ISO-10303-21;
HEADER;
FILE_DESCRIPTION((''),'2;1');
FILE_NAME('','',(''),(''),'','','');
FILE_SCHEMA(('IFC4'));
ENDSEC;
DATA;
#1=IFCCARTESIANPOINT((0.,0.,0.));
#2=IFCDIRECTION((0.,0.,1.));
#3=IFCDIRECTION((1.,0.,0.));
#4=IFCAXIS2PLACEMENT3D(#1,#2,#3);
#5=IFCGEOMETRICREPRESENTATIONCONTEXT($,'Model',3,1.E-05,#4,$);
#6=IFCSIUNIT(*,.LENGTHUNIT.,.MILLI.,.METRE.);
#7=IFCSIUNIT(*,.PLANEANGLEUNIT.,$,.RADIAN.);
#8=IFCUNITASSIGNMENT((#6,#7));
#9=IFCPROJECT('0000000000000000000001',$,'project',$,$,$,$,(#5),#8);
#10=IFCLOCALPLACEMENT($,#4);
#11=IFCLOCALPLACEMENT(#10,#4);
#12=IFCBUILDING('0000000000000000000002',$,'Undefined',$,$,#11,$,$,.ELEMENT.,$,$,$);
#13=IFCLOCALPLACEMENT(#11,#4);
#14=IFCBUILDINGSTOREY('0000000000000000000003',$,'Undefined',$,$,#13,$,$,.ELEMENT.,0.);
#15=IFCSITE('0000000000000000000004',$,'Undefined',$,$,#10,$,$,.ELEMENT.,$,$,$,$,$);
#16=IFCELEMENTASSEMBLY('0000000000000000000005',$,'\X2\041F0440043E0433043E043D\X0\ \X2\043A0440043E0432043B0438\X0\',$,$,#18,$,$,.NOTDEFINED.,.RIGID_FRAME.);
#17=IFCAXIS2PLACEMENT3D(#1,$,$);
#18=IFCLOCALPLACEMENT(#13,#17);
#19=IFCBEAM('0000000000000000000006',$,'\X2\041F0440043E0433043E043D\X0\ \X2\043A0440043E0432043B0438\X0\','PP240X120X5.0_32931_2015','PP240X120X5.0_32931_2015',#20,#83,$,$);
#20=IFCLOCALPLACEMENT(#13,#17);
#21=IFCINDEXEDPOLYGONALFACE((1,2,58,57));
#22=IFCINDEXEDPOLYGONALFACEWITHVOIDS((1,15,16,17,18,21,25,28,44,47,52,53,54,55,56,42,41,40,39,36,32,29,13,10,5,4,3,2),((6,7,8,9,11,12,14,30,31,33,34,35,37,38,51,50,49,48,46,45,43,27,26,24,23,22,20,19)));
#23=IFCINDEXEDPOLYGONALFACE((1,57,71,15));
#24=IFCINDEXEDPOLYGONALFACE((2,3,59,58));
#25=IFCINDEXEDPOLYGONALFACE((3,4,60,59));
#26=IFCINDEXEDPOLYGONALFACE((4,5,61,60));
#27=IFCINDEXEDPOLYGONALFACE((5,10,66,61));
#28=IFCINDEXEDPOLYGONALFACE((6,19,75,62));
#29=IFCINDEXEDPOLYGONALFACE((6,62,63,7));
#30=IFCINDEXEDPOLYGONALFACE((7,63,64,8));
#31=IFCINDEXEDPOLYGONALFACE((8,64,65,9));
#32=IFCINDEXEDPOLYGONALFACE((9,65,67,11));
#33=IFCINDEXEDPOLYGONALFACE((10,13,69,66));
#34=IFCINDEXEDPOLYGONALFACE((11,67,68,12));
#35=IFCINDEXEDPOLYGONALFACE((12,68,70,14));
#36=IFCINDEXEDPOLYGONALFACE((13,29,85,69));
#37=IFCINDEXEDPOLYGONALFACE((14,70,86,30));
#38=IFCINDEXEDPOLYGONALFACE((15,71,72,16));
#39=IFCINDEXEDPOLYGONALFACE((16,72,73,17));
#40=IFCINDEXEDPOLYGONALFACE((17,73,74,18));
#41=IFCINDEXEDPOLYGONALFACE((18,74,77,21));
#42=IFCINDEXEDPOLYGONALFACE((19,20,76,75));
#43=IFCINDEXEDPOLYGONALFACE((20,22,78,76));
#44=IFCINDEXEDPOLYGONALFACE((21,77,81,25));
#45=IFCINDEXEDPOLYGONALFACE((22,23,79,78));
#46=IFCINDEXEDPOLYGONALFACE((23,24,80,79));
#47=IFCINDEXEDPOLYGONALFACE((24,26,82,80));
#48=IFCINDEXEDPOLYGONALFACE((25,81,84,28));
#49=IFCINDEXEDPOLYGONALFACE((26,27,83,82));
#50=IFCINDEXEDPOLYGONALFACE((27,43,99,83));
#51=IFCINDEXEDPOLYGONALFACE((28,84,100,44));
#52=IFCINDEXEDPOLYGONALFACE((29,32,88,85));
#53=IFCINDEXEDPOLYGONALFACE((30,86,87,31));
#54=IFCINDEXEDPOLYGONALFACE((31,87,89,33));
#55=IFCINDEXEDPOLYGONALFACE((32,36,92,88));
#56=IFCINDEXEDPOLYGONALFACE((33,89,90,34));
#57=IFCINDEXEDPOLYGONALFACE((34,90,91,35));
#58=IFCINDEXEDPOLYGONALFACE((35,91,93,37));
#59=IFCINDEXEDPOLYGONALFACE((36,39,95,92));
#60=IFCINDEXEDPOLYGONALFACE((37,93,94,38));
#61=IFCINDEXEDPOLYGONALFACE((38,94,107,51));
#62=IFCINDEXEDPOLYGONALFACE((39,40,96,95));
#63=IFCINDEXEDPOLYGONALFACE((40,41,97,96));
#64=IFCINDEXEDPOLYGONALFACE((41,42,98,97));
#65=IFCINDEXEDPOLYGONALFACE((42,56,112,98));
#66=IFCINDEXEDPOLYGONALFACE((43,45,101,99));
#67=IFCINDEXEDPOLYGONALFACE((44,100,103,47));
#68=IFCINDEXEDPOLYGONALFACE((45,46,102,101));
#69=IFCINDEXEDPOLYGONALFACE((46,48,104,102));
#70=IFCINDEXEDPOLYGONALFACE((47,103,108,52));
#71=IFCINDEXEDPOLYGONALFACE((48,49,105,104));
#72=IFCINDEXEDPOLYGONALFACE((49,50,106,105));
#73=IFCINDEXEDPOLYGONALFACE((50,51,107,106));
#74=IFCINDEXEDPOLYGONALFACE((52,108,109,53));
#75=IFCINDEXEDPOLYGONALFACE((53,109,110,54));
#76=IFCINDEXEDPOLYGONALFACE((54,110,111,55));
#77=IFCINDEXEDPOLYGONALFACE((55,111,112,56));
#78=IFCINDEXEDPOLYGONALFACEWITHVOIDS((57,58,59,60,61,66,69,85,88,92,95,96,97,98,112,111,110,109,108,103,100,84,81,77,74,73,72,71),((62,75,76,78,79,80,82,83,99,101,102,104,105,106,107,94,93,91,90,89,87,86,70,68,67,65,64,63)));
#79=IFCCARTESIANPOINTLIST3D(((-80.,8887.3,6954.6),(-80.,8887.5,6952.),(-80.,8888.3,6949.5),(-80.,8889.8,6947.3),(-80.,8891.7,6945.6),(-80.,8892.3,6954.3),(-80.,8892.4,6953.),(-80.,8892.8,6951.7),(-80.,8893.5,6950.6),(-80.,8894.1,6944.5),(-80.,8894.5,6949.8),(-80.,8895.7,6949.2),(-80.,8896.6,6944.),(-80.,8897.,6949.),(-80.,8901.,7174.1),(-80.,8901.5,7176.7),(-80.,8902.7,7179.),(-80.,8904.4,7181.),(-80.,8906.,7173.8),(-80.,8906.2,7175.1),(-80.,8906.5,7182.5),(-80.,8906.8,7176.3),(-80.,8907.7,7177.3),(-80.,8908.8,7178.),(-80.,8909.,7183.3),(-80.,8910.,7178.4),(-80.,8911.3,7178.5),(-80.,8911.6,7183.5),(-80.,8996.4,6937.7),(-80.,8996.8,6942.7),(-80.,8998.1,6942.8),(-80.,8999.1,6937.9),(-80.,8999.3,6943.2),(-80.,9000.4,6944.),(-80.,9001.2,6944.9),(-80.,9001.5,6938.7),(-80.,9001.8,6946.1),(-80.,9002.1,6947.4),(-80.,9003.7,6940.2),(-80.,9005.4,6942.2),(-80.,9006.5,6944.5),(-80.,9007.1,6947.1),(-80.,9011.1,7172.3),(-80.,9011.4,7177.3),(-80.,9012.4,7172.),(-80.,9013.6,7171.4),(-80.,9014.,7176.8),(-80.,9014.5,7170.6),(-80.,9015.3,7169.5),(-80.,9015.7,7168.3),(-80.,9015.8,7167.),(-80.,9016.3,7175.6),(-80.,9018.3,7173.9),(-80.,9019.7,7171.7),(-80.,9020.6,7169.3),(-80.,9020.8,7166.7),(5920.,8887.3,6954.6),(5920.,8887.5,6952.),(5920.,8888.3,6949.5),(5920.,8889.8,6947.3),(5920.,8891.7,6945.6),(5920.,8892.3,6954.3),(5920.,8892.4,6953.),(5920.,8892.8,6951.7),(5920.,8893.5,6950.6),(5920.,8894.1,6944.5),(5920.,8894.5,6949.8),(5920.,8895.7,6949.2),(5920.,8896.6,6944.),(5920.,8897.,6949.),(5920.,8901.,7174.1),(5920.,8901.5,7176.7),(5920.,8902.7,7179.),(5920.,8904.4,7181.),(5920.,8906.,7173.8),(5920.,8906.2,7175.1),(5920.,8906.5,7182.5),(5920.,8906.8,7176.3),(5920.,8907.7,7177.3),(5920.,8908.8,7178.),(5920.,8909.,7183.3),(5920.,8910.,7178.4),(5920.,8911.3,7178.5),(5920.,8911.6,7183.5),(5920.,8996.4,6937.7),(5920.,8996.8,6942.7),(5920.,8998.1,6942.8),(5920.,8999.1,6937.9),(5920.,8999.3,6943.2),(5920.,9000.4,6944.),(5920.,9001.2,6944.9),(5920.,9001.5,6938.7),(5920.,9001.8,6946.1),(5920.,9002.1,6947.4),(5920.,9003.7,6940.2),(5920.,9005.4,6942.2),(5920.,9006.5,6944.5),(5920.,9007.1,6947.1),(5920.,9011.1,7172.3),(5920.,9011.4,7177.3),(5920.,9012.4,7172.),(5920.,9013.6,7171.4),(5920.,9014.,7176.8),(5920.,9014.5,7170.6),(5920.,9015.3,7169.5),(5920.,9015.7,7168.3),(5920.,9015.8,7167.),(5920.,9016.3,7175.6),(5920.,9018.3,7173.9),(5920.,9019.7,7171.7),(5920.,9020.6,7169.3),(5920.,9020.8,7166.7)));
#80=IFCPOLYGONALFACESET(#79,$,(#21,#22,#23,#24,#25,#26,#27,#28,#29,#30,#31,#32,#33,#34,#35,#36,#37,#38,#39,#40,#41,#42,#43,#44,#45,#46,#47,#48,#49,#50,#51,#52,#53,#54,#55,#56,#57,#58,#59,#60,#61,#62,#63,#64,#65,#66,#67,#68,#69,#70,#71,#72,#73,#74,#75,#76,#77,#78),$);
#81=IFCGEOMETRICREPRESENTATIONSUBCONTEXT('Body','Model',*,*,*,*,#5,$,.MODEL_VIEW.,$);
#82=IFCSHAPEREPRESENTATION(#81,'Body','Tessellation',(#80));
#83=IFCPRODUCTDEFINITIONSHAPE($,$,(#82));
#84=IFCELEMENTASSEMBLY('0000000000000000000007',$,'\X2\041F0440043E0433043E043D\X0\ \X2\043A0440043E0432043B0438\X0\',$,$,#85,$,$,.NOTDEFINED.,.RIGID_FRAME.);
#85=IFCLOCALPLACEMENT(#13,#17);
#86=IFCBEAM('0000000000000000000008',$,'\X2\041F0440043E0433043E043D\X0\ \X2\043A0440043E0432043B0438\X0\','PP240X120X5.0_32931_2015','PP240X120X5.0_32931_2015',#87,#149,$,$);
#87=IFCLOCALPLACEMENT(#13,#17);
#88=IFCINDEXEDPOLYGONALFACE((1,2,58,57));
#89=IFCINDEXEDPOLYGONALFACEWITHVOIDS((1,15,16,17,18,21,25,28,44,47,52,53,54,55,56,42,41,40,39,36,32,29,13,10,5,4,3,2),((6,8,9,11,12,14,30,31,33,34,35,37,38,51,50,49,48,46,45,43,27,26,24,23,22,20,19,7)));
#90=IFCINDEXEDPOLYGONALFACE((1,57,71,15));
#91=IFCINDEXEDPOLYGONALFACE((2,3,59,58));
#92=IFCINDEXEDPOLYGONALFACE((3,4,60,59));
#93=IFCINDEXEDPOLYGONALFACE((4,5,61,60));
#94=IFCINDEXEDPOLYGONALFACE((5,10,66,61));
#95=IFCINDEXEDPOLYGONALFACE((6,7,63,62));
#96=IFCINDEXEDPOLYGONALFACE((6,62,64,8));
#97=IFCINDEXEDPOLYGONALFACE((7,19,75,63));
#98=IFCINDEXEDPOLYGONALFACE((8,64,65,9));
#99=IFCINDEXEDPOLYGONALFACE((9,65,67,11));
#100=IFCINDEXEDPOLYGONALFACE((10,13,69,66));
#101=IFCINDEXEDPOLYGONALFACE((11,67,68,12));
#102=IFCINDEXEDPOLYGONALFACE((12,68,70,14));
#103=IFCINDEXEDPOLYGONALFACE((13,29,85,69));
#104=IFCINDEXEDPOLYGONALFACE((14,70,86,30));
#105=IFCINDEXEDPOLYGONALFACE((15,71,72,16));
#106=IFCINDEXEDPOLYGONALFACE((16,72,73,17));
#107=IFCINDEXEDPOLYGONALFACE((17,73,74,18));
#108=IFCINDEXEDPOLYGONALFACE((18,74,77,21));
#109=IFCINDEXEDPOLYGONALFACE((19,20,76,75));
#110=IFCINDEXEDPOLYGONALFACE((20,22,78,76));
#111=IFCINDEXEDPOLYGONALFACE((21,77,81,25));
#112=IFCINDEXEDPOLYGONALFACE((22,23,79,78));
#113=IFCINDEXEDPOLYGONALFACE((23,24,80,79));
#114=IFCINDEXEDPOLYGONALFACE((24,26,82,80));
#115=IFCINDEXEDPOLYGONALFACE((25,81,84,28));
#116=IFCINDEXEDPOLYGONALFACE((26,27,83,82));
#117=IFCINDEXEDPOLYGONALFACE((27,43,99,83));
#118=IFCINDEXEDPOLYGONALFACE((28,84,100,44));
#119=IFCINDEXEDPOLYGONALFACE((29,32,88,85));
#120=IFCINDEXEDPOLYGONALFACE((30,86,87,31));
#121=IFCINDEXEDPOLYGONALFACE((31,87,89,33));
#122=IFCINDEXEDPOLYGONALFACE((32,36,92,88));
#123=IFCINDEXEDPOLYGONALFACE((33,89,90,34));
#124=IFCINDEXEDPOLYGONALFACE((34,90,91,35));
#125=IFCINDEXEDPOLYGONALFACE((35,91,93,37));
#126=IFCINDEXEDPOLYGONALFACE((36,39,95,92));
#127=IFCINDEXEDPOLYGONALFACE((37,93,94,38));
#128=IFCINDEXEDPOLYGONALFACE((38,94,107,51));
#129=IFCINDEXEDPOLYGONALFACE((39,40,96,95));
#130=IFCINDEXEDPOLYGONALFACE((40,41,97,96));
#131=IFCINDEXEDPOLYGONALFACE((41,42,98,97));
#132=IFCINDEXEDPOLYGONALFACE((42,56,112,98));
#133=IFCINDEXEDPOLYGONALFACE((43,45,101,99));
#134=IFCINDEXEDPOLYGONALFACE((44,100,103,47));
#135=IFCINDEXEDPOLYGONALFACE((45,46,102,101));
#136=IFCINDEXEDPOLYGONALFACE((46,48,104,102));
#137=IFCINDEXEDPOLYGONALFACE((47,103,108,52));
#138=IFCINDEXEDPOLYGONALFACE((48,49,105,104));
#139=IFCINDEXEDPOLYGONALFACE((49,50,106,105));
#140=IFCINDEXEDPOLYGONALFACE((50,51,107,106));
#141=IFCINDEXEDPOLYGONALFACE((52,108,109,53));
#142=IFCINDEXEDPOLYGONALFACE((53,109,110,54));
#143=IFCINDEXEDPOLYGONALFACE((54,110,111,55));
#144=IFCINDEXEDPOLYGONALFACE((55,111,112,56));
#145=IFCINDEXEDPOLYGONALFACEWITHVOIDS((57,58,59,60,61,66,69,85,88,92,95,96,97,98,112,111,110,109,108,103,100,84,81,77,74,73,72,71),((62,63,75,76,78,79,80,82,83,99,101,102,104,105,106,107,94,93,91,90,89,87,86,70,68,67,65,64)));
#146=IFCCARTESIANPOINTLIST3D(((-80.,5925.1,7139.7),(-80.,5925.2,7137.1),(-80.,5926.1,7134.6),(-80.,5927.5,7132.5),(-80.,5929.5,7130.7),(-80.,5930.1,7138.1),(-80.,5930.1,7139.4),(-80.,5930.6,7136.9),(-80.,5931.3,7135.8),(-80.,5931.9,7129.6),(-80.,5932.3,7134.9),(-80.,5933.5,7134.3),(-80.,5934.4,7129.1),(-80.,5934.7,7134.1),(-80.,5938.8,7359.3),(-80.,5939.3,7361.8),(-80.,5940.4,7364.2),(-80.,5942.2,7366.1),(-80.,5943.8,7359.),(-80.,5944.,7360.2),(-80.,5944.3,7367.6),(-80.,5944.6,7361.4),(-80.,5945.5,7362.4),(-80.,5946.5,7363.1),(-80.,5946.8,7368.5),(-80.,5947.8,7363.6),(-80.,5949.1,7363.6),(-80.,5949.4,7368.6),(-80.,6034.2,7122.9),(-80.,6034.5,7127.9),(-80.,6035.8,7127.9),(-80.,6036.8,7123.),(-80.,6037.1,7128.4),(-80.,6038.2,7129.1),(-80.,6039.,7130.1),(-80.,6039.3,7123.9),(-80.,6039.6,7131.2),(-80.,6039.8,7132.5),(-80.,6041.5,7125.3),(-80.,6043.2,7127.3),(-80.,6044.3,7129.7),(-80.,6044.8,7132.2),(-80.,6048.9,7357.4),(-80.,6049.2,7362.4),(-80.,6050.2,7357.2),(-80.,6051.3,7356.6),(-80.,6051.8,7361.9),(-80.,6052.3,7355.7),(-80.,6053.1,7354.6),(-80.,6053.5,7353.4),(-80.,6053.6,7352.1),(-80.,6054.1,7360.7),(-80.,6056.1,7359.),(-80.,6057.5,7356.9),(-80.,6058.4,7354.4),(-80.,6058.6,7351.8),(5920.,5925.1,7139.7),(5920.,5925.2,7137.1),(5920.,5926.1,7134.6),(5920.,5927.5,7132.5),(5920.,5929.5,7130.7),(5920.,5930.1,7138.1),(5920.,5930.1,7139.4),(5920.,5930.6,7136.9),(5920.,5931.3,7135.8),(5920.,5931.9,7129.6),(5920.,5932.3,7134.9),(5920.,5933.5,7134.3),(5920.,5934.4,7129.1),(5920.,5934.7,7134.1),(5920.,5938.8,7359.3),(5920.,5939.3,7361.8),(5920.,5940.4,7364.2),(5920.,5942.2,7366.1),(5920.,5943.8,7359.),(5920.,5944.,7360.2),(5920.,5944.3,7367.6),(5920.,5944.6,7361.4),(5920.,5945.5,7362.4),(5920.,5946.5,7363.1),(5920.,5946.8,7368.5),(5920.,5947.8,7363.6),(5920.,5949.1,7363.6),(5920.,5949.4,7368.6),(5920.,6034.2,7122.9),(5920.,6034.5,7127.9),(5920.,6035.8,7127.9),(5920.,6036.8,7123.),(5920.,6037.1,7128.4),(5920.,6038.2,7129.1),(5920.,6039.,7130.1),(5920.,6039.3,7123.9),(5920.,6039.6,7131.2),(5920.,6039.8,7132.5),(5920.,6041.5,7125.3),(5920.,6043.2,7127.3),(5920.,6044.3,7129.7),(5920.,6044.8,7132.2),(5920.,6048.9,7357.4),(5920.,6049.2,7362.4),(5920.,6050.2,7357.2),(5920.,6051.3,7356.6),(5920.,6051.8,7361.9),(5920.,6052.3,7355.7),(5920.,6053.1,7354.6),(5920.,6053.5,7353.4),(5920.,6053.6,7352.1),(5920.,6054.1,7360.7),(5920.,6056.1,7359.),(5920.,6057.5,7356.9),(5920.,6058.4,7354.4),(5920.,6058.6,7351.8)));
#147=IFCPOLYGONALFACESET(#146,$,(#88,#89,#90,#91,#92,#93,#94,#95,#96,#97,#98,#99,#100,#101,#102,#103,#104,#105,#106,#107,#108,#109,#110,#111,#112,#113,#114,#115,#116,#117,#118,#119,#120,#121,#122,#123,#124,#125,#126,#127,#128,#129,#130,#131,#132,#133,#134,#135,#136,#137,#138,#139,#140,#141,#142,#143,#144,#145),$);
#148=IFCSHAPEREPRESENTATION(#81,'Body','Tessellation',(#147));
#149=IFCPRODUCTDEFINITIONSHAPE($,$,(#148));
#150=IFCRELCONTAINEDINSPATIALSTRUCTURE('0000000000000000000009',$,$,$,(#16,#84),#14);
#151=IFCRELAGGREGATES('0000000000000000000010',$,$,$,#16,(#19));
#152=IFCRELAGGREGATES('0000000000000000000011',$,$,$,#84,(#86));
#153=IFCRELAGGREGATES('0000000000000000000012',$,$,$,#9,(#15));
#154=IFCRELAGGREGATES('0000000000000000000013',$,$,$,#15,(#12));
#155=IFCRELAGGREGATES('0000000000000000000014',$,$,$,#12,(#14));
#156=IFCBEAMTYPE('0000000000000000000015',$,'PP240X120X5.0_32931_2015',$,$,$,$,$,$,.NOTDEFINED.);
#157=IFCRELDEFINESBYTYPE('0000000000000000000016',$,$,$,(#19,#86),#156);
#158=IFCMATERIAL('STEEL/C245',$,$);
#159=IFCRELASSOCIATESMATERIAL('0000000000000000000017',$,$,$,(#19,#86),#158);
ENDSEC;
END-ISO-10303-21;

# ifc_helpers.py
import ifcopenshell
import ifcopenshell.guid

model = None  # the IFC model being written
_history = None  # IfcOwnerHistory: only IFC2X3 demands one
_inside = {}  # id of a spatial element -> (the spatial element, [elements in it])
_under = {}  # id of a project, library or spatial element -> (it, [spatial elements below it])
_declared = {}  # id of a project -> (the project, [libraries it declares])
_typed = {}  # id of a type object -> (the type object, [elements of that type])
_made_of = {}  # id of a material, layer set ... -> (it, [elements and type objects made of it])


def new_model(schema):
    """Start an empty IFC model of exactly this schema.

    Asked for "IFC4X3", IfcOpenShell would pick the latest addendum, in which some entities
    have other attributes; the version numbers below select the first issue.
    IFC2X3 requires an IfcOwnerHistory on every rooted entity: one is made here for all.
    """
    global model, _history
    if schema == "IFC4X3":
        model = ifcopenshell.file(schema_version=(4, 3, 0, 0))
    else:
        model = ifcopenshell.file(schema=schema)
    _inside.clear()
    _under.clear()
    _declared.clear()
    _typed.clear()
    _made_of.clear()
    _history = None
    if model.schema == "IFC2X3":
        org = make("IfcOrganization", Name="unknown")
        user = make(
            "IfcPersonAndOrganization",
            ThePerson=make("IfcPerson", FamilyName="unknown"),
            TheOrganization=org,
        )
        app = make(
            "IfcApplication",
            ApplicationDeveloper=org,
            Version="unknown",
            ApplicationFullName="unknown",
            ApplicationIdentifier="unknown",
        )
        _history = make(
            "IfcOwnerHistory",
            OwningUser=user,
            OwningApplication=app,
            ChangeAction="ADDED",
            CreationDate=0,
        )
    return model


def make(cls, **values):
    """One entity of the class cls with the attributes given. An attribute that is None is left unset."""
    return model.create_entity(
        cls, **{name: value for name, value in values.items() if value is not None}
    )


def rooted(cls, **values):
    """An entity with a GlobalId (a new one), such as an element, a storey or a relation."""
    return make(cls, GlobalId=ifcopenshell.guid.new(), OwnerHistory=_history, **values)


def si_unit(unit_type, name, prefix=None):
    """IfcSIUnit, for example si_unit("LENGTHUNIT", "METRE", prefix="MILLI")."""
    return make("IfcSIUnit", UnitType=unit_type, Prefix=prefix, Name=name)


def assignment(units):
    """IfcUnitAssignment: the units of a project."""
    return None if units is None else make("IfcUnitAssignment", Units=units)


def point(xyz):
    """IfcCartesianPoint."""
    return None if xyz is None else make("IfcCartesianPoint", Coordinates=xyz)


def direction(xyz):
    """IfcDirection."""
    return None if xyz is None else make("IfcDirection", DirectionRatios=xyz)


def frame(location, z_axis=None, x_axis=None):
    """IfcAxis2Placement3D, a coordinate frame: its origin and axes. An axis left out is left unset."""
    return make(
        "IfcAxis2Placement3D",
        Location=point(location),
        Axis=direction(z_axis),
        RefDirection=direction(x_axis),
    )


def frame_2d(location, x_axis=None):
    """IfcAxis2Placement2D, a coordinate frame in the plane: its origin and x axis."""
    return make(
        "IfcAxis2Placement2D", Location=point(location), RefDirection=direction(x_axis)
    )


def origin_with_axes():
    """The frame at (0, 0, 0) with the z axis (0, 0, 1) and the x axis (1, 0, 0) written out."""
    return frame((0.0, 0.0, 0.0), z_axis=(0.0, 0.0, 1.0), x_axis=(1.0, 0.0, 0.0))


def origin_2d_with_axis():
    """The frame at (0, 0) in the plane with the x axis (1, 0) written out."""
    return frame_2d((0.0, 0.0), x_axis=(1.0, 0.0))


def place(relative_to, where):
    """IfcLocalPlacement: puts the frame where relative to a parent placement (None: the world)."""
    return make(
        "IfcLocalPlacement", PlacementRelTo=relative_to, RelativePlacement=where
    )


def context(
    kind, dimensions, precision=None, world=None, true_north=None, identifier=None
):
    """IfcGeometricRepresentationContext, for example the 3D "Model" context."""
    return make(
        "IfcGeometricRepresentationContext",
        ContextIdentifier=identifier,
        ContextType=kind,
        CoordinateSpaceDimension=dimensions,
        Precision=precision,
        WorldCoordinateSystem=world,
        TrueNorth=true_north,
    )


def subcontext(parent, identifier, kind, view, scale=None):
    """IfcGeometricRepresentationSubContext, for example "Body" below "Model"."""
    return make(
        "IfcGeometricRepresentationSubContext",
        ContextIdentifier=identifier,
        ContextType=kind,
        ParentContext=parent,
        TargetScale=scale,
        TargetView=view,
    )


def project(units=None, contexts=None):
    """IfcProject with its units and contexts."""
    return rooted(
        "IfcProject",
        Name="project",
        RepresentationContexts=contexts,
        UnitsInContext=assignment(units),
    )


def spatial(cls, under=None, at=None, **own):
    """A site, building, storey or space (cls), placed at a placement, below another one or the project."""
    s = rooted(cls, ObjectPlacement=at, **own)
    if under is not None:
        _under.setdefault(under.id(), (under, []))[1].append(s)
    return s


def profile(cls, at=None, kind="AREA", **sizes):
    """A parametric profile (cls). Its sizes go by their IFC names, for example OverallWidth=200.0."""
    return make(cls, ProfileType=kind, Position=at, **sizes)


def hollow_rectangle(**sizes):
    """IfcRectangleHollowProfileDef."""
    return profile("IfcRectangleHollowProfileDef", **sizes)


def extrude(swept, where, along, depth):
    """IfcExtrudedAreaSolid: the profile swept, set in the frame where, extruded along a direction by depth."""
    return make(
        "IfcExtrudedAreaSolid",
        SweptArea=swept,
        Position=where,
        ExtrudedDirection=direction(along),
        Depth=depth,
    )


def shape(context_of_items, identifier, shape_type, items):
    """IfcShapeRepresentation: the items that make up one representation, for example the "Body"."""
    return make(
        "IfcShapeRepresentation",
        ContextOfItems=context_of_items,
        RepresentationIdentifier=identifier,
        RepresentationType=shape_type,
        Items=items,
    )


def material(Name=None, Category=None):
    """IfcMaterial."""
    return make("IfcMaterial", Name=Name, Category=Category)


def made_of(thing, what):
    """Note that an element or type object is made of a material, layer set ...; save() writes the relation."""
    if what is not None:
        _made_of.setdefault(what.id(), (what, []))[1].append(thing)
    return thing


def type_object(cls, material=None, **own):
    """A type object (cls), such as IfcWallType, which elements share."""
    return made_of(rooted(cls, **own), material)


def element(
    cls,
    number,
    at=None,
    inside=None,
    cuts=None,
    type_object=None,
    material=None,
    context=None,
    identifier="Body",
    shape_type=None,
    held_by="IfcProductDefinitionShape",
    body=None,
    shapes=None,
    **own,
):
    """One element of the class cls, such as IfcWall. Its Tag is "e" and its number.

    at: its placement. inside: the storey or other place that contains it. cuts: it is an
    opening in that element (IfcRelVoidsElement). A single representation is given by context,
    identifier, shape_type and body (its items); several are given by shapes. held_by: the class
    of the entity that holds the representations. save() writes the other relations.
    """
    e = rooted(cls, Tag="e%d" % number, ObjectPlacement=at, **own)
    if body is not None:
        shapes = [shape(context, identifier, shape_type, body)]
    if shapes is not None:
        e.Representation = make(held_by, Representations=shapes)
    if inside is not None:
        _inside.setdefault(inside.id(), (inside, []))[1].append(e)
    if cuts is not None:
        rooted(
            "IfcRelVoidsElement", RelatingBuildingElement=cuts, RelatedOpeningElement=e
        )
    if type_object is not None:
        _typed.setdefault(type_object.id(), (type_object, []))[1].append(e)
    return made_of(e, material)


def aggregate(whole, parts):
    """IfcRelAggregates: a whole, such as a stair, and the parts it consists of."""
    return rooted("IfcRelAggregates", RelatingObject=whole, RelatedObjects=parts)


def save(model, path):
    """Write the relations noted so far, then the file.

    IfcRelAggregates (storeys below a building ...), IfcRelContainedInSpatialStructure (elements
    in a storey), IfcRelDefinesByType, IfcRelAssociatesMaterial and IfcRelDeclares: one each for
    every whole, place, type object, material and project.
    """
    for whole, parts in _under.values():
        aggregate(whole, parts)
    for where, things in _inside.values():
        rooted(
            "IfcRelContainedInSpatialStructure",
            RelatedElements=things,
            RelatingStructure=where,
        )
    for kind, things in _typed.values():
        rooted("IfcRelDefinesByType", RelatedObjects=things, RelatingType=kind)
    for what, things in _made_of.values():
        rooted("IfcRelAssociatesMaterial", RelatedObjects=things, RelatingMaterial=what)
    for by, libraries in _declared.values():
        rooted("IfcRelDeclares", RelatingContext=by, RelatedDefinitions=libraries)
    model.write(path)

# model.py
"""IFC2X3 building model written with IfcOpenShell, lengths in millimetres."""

from ifc_helpers import new_model, si_unit, frame, origin_with_axes, origin_2d_with_axis, place, context, subcontext, project, spatial, hollow_rectangle, extrude, material, type_object, element, aggregate, save


model = new_model("IFC2X3")

# Units and contexts
model_context = context("Model", 3, precision=1e-05, world=origin_with_axes())
body_context = subcontext(model_context, "Body", "Model", "MODEL_VIEW")
ifc_project = project(units=[si_unit("LENGTHUNIT", "METRE", prefix="MILLI"), si_unit("PLANEANGLEUNIT", "RADIAN")], contexts=[model_context])

# Site, building, storey
site_placement = place(None, origin_with_axes())
site = spatial("IfcSite", under=ifc_project, at=site_placement, Name="Undefined", CompositionType="ELEMENT")
building_placement = place(site_placement, origin_with_axes())
building = spatial("IfcBuilding", under=site, at=building_placement, Name="Undefined", CompositionType="ELEMENT")
storey_placement = place(building_placement, origin_with_axes())
storey = spatial("IfcBuildingStorey", under=building, at=storey_placement, Name="Undefined", CompositionType="ELEMENT", Elevation=0.0)

# Shared definitions
ifc_material = material(Name="STEEL/C245")

# Element assemblies, beams
beam_type_1 = type_object("IfcBeamType", Name="PP240X120X5.0_32931_2015", PredefinedType="NOTDEFINED")
assembly_1_placement = place(storey_placement, origin_with_axes())
assembly_1 = element("IfcElementAssembly", 1, at=assembly_1_placement, inside=storey, Name="Прогон кровли", AssemblyPlace="NOTDEFINED", PredefinedType="RIGID_FRAME")
beam_1_placement = place(assembly_1_placement, frame((5920.0, 8954.0, 7060.6), z_axis=(0.0, 0.062378, 0.998053), x_axis=(-1.0, 0.0, 0.0)))
beam_1 = element("IfcBeam", 2, at=beam_1_placement, type_object=beam_type_1, material=ifc_material, Name="Прогон кровли", Description="PP240X120X5.0_32931_2015", ObjectType="PP240X120X5.0_32931_2015", context=body_context, shape_type="SweptSolid", body=[
    extrude(hollow_rectangle(XDim=120.0, YDim=240.0, WallThickness=5.0, InnerFilletRadius=5.0, OuterFilletRadius=10.0, at=origin_2d_with_axis()), frame((6000.0, 0.0, 0.0), z_axis=(-1.0, 0.0, 0.0), x_axis=(0.0, -1.0, 0.0)), (0.0, 0.0, 1.0), 6000.0),
])
aggregate(assembly_1, [beam_1])
assembly_2_placement = place(storey_placement, origin_with_axes())
assembly_2 = element("IfcElementAssembly", 3, at=assembly_2_placement, inside=storey, Name="Прогон кровли", AssemblyPlace="NOTDEFINED", PredefinedType="RIGID_FRAME")
beam_2_placement = place(assembly_2_placement, frame((5920.0, 5991.8, 7245.7), z_axis=(0.0, 0.062378, 0.998053), x_axis=(-1.0, 0.0, 0.0)))
beam_2 = element("IfcBeam", 4, at=beam_2_placement, type_object=beam_type_1, material=ifc_material, Name="Прогон кровли", Description="PP240X120X5.0_32931_2015", ObjectType="PP240X120X5.0_32931_2015", context=body_context, shape_type="SweptSolid", body=[
    extrude(hollow_rectangle(XDim=120.0, YDim=240.0, WallThickness=5.0, InnerFilletRadius=5.0, OuterFilletRadius=10.0, at=origin_2d_with_axis()), frame((6000.0, 0.0, 0.0), z_axis=(-1.0, 0.0, 0.0), x_axis=(0.0, -1.0, 0.0)), (0.0, 0.0, 1.0), 6000.0),
])
aggregate(assembly_2, [beam_2])

save(model, "model.ifc")
